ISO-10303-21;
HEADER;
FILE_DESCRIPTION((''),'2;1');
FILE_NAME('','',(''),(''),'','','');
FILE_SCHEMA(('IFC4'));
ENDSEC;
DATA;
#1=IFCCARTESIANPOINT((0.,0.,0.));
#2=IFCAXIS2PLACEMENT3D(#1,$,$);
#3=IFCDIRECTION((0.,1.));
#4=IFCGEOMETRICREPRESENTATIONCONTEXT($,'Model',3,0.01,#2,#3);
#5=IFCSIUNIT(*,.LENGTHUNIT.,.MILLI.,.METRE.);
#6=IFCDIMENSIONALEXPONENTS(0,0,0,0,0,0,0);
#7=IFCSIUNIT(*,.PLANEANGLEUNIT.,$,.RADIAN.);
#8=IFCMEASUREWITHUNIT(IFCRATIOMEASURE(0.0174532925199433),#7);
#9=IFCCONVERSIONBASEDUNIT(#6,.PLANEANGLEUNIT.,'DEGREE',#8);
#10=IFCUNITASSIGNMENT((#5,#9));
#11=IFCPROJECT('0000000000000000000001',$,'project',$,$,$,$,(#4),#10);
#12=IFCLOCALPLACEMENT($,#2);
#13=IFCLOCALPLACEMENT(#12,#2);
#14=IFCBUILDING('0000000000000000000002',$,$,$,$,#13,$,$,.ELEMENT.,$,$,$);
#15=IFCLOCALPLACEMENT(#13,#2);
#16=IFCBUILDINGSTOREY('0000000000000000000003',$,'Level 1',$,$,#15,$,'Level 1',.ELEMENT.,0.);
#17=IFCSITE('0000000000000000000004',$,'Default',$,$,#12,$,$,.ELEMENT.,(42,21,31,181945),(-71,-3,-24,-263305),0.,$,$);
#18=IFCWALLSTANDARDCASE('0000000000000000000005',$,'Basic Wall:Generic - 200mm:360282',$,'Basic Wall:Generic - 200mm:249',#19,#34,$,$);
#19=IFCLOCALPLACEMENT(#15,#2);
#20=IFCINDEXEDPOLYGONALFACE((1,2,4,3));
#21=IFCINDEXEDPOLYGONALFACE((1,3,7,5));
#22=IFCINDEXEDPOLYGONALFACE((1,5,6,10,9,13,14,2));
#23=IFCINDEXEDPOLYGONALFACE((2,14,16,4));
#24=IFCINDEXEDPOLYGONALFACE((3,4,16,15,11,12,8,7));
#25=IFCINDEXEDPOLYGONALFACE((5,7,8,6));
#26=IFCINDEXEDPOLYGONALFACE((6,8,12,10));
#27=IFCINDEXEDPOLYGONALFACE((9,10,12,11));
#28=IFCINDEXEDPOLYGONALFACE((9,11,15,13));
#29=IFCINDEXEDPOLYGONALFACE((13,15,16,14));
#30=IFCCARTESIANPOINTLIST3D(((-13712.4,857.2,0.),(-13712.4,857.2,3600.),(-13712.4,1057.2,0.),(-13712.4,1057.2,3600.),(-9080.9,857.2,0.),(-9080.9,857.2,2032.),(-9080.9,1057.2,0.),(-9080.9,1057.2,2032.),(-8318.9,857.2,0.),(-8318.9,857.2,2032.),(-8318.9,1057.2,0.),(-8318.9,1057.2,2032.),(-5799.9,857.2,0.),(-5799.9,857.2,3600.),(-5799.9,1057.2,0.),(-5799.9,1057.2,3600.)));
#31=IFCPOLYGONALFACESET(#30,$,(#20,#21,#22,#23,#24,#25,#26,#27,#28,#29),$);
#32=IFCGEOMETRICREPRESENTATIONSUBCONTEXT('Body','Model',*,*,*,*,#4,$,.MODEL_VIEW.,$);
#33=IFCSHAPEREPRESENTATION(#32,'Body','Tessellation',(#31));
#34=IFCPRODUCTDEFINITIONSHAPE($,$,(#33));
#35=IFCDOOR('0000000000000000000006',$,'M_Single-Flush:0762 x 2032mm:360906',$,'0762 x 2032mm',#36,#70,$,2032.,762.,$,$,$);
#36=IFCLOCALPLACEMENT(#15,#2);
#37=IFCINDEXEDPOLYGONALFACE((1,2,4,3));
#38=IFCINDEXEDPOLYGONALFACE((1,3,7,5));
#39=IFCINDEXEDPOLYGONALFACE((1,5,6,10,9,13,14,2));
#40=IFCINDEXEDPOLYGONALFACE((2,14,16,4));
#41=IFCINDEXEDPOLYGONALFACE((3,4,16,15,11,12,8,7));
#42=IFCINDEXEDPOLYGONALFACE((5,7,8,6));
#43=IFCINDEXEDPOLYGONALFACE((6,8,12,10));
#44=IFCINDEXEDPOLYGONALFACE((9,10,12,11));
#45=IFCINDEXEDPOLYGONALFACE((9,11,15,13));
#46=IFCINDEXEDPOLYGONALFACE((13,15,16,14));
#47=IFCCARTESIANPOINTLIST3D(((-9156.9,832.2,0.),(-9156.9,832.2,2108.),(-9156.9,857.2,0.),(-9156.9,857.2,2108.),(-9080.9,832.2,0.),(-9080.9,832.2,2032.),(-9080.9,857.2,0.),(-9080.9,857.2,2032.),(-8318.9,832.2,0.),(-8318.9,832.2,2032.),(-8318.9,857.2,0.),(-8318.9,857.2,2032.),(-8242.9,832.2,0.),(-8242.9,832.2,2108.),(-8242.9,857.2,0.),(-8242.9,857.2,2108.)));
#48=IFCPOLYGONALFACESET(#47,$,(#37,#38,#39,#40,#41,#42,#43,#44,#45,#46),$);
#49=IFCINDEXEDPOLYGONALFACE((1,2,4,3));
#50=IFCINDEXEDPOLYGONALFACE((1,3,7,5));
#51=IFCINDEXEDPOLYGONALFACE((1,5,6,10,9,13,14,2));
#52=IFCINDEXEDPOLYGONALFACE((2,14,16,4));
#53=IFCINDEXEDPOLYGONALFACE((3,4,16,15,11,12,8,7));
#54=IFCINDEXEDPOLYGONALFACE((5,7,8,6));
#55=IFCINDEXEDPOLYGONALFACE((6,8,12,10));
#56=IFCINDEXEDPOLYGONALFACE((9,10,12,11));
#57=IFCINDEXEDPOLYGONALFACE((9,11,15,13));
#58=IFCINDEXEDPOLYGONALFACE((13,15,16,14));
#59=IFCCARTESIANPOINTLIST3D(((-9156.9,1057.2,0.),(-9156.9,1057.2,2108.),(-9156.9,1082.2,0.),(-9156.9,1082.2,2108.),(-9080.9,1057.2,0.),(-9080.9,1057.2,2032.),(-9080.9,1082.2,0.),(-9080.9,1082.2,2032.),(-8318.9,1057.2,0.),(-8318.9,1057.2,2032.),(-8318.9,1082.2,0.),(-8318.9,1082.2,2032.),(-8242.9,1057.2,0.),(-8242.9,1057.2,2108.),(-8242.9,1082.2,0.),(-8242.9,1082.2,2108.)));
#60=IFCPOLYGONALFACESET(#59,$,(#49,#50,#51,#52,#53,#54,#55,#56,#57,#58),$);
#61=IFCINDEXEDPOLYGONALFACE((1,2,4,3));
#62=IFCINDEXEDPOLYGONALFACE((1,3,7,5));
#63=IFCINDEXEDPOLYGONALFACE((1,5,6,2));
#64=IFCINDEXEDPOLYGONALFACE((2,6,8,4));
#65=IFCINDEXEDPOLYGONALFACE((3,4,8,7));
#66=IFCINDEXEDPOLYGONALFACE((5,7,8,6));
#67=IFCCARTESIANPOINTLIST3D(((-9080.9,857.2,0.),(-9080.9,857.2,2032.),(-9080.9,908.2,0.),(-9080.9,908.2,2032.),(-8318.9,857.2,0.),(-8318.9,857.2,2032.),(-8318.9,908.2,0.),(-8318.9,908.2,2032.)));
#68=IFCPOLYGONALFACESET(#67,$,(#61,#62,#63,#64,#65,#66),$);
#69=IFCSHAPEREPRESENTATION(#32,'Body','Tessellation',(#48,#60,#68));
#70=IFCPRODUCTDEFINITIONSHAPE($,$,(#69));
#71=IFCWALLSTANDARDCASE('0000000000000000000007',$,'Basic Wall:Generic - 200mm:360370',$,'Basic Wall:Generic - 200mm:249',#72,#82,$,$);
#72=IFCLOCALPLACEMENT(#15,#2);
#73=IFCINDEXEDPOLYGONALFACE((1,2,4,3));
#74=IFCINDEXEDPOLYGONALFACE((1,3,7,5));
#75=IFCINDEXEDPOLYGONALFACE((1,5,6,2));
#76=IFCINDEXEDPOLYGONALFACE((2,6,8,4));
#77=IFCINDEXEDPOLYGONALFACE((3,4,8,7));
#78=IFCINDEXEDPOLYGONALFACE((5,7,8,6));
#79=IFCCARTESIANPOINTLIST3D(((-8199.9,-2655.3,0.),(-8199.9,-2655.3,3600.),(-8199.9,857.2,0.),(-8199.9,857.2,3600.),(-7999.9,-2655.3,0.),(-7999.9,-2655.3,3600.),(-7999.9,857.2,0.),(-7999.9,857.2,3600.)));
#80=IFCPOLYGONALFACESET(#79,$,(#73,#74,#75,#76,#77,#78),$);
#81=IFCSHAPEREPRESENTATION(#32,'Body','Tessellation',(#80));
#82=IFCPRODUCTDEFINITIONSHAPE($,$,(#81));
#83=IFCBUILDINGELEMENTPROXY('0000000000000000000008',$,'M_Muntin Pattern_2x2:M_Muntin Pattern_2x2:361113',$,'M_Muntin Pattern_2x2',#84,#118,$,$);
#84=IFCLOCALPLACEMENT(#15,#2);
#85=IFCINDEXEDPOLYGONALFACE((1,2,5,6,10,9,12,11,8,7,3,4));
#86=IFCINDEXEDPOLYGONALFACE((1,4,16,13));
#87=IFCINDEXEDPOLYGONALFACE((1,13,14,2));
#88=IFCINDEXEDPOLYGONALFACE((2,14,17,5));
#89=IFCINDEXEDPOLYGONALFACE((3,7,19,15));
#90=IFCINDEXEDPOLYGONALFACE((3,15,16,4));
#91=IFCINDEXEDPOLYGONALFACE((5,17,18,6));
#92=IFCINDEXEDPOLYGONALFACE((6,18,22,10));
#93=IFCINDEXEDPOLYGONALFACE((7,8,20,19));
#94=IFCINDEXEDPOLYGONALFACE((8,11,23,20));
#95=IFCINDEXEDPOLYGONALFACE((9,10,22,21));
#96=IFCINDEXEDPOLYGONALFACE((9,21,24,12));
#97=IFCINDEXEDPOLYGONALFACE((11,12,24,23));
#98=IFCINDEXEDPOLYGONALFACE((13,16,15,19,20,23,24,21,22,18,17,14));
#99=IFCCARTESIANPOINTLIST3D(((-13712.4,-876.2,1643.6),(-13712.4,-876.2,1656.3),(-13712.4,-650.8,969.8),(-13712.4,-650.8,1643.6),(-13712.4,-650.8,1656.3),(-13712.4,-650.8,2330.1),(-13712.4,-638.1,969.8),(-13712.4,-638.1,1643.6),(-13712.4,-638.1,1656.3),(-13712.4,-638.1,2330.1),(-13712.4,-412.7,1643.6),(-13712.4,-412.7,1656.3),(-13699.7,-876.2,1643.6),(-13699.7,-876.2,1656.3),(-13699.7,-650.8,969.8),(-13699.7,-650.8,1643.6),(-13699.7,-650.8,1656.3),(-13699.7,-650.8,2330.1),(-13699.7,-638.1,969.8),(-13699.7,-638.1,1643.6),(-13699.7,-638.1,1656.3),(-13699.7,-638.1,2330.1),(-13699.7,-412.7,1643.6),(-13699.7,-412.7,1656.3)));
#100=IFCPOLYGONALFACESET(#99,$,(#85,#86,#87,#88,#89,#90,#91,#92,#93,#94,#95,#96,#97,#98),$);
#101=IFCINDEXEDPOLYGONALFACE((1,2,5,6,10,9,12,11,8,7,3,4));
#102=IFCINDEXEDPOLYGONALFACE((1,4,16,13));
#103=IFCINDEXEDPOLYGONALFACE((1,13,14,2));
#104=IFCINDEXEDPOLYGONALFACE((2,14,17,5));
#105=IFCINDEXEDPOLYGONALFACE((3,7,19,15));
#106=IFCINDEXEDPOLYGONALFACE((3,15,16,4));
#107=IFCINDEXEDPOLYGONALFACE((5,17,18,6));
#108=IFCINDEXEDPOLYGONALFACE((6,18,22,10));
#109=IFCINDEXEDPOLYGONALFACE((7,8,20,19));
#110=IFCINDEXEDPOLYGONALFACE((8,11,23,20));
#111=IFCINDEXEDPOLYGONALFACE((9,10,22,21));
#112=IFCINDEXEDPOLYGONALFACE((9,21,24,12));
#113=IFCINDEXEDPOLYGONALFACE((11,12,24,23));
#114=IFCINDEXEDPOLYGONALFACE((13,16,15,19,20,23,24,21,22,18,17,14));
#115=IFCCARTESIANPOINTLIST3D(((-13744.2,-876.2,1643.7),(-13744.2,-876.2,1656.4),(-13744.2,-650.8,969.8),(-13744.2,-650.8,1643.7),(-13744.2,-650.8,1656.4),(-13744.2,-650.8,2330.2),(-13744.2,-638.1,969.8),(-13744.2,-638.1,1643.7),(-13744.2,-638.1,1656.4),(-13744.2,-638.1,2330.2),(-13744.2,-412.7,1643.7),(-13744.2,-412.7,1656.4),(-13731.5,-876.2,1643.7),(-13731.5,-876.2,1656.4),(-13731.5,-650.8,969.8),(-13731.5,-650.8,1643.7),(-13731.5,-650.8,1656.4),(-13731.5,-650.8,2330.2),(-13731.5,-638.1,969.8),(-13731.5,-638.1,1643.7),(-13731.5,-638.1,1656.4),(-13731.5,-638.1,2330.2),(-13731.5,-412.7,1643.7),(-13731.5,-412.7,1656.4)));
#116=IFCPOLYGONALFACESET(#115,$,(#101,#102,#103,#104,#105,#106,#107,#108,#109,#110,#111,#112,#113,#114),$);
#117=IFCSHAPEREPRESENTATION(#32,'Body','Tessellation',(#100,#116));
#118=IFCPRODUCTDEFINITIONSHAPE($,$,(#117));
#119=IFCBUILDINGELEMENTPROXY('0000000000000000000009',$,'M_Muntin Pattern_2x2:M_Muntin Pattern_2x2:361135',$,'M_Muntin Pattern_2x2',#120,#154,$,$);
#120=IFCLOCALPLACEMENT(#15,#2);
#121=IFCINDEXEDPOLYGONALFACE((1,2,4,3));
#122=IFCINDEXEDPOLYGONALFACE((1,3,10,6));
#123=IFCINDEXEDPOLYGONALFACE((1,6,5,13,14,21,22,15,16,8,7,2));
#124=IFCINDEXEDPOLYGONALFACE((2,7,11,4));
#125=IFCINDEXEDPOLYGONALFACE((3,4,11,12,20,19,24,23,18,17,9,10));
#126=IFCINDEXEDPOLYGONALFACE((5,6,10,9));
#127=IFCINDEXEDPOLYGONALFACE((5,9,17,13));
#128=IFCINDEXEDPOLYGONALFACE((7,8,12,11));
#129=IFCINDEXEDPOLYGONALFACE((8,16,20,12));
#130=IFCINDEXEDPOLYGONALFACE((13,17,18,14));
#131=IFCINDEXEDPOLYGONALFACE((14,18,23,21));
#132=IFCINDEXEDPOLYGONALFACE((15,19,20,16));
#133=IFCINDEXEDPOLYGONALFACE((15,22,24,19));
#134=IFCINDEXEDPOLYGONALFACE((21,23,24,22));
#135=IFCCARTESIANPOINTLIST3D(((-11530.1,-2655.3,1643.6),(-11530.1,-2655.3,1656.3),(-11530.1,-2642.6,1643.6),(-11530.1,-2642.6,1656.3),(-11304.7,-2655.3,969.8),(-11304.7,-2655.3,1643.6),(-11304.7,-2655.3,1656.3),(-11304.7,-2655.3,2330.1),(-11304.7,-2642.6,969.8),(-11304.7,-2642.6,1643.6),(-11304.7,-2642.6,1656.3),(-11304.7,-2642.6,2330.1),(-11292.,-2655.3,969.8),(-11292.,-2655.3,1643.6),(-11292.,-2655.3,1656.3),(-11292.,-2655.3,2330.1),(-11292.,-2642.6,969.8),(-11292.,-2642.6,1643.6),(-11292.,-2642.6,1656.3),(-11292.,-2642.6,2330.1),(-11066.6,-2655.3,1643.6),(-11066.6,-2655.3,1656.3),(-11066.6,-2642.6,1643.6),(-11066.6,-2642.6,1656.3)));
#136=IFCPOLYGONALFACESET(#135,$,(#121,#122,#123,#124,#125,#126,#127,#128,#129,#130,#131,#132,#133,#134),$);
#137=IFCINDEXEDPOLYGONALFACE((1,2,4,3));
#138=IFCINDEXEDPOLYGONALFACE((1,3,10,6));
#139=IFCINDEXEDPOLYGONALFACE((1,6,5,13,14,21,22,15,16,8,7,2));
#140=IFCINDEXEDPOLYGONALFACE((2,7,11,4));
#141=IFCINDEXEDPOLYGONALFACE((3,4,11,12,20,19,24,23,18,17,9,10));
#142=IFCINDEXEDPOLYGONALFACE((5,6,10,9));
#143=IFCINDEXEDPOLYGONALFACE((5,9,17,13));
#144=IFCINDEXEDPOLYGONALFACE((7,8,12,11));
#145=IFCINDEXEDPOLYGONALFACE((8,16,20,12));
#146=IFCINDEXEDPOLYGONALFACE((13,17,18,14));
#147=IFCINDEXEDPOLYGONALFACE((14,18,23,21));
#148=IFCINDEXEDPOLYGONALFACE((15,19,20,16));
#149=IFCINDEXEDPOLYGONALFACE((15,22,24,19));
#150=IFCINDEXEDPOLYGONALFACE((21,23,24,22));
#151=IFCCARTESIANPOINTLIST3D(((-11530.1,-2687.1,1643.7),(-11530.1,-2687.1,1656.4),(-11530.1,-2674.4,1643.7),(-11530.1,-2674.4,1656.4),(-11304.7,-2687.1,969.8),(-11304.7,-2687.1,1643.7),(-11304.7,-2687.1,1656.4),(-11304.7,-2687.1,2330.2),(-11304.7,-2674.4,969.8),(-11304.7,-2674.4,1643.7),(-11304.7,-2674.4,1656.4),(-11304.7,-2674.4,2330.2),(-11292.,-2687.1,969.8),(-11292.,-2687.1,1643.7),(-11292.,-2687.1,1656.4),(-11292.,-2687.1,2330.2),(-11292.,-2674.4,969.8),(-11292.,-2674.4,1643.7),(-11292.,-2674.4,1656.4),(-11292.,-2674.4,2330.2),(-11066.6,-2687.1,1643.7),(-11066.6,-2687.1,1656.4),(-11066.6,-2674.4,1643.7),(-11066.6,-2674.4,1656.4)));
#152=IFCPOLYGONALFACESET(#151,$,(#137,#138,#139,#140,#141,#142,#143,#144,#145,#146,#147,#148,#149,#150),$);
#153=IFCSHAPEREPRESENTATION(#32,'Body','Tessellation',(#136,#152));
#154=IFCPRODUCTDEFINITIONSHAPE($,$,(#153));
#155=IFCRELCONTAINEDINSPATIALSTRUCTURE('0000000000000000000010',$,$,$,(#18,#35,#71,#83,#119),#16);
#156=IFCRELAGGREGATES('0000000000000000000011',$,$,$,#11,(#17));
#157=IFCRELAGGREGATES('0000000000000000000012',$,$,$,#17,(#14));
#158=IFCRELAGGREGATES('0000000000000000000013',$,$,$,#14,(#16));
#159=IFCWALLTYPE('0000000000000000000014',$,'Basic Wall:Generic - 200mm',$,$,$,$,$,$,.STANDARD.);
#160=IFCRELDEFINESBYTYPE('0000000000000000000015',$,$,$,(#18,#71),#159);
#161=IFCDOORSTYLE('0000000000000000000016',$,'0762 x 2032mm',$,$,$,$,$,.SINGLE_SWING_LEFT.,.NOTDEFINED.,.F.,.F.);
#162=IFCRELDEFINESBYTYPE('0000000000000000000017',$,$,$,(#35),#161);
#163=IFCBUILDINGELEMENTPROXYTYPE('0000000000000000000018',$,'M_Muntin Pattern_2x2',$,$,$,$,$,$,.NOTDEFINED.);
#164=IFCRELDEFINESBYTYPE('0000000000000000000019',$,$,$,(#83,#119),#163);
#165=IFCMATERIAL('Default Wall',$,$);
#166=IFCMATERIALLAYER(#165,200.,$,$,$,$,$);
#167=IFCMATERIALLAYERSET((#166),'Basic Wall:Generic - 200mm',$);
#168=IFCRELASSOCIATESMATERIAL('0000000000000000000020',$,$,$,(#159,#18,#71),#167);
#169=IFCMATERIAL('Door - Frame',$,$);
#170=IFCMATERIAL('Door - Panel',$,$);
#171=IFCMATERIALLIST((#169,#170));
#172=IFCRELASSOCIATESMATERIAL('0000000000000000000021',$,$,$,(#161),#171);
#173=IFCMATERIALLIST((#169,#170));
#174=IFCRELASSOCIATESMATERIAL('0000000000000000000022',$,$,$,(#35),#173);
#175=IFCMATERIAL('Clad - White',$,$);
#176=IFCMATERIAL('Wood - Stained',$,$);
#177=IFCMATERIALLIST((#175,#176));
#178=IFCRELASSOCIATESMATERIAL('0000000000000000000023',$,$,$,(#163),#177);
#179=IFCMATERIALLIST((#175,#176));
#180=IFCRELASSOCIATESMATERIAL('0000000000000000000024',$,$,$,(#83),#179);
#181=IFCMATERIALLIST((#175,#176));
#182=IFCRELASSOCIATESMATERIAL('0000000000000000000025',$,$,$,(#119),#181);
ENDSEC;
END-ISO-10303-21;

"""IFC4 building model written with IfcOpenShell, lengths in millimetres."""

from ifc_helpers import new_model, entity, si_unit, converted_unit, direction, frame, frame_2d, origin, place, context, subcontext, project, spatial, polyline, rectangle, outline, extrude, clip, bounded_halfspace, source, transform, mapped, material, material_list, layer, layer_set, layer_usage, type_object, type_shapes, element, fill, save


model = new_model("IFC4")

# Units and contexts
model_context = context("Model", 3, precision=0.01, world=origin(), true_north=direction((0.0, 1.0)))
body_context = subcontext(model_context, "Body", "Model", "MODEL_VIEW")
ifc_project = project(units=[si_unit("LENGTHUNIT", "METRE", prefix="MILLI"), converted_unit("PLANEANGLEUNIT", "DEGREE", entity("IfcRatioMeasure", 0.0174532925199433), si_unit("PLANEANGLEUNIT", "RADIAN"), dimensions=[0, 0, 0, 0, 0, 0, 0])], contexts=[model_context])

# Site, building, storey
site_placement = place(None, origin())
site = spatial("IfcSite", under=ifc_project, at=site_placement, Name="Default", CompositionType="ELEMENT", RefLatitude=(42, 21, 31, 181945), RefLongitude=(-71, -3, -24, -263305), RefElevation=0.0)
building_placement = place(site_placement, origin())
building = spatial("IfcBuilding", under=site, at=building_placement, CompositionType="ELEMENT")
storey_placement = place(building_placement, origin())
storey = spatial("IfcBuildingStorey", under=building, at=storey_placement, Name="Level 1", LongName="Level 1", CompositionType="ELEMENT", Elevation=0.0)

# Shared definitions
ifc_material_1 = material(Name="Default Wall")

# Wall, opening, door
ifc_material_2 = material(Name="Door - Frame")
ifc_material_3 = material(Name="Door - Panel")
ifc_layer_1 = layer(ifc_material_1, 200.0)
ifc_layer_set_1 = layer_set([ifc_layer_1], Name="Basic Wall:Generic - 200mm")
wall_type_1 = type_object("IfcWallType", Name="Basic Wall:Generic - 200mm", PredefinedType="STANDARD", material=ifc_layer_set_1)
ifc_material_list_1 = material_list([ifc_material_2, ifc_material_3])
door_style_1 = type_object("IfcDoorStyle", Name="0762 x 2032mm", ConstructionType="NOTDEFINED", OperationType="SINGLE_SWING_LEFT", ParameterTakesPrecedence=False, Sizeable=False, material=ifc_material_list_1)
shared_shape_1 = source(origin(), body_context, "Body", "SweptSolid", [
    extrude(outline(polyline([(-457.0, -1073.0), (457.0, -1073.0), (457.0, 1035.0), (381.0, 1035.0), (381.0, -997.0), (-381.0, -997.0), (-381.0, 1035.0), (-457.0, 1035.0), (-457.0, -1073.0)])), frame((381.0, 225.0, 1035.0), z_axis=(0.0, -1.0, 0.0), x_axis=(-1.0, 0.0, 0.0)), (0.0, 0.0, 1.0), 25.0),
    extrude(outline(polyline([(-1073.0, -457.0), (1035.0, -457.0), (1035.0, -381.0), (-997.0, -381.0), (-997.0, 381.0), (1035.0, 381.0), (1035.0, 457.0), (-1073.0, 457.0), (-1073.0, -457.0)])), frame((381.0, 0.0, 1035.0), z_axis=(0.0, -1.0, 0.0), x_axis=(0.0, 0.0, -1.0)), (0.0, 0.0, 1.0), 25.0),
    extrude(rectangle(XDim=762.0, YDim=51.0, at=frame_2d((0.0, 0.0), x_axis=(1.0, 0.0))), frame((381.0, 174.5, 0.0)), (0.0, 0.0, 1.0), 2032.0),
])
type_shapes(door_style_1, [shared_shape_1])
ifc_layer_usage_1 = layer_usage(ifc_layer_set_1, "AXIS2", "NEGATIVE", 100.0)
wall_1_placement = place(storey_placement, frame((-5799.9, 957.2, 0.0), z_axis=(0.0, 0.0, 1.0), x_axis=(-1.0, 0.0, 0.0)))
wall_1 = element("IfcWallStandardCase", 1, at=wall_1_placement, inside=storey, type_object=wall_type_1, material=ifc_layer_usage_1, Name="Basic Wall:Generic - 200mm:360282", ObjectType="Basic Wall:Generic - 200mm:249", context=body_context, shape_type="Clipping", body=[
    clip(extrude(rectangle(XDim=7912.5, YDim=200.0, at=frame_2d((3956.2, 0.0), x_axis=(-1.0, 0.0))), origin(), (0.0, 0.0, 1.0), 3600.0), bounded_halfspace(frame((0.0, -100.0, 3600.0), z_axis=(0.0, 0.0, -1.0), x_axis=(-1.0, 0.0, 0.0)), True, frame((0.0, -100.0, 3600.0)), polyline([(0.0, 0.0), (200.0, 0.0), (4500.0, 0.0), (4700.0, 0.0), (7912.5, 0.0), (7912.5, 200.0), (2400.0, 200.0), (2200.0, 200.0), (0.0, 200.0), (0.0, 0.0)]))),
])
opening_1_placement = place(wall_1_placement, frame((2519.0, -100.0, 0.0)))
opening_1 = element("IfcOpeningElement", 2, at=opening_1_placement, cuts=wall_1, ObjectType="Opening", context=body_context, shape_type="SweptSolid", body=[
    extrude(rectangle(XDim=762.0, YDim=2032.0, at=frame_2d((1016.0, 381.0), x_axis=(0.0, -1.0))), frame((0.0, 0.0, 0.0), z_axis=(0.0, 1.0, 0.0), x_axis=(0.0, 0.0, 1.0)), (0.0, 0.0, 1.0), 200.0),
])
ifc_material_list_2 = material_list([ifc_material_2, ifc_material_3])
door_1_placement = place(opening_1_placement, origin())
door_1 = element("IfcDoor", 3, at=door_1_placement, inside=storey, type_object=door_style_1, material=ifc_material_list_2, Name="M_Single-Flush:0762 x 2032mm:360906", ObjectType="0762 x 2032mm", OverallHeight=2032.0, OverallWidth=762.0, context=body_context, shape_type="MappedRepresentation", body=[
    mapped(shared_shape_1, transform((0.0, 0.0, 0.0), scale=1.0)),
])
fill(opening_1, door_1)

# Wall
ifc_layer_usage_2 = layer_usage(ifc_layer_set_1, "AXIS2", "NEGATIVE", 100.0)
wall_2_placement = place(storey_placement, frame((-8099.9, 857.2, 0.0), z_axis=(0.0, 0.0, 1.0), x_axis=(0.0, -1.0, 0.0)))
element("IfcWallStandardCase", 4, at=wall_2_placement, inside=storey, type_object=wall_type_1, material=ifc_layer_usage_2, Name="Basic Wall:Generic - 200mm:360370", ObjectType="Basic Wall:Generic - 200mm:249", context=body_context, shape_type="Clipping", body=[
    clip(extrude(rectangle(XDim=3512.5, YDim=200.0, at=frame_2d((1756.2, 0.0), x_axis=(-1.0, 0.0))), origin(), (0.0, 0.0, 1.0), 3600.0), bounded_halfspace(frame((0.0, -100.0, 3600.0), z_axis=(0.0, 0.0, -1.0), x_axis=(0.0, 1.0, 0.0)), True, frame((0.0, -100.0, 3600.0)), polyline([(0.0, 0.0), (3512.5, 0.0), (3512.5, 200.0), (0.0, 200.0), (0.0, 0.0)]))),
])

# Building element proxies
ifc_material_4 = material(Name="Clad - White")
ifc_material_5 = material(Name="Wood - Stained")
ifc_material_list_3 = material_list([ifc_material_4, ifc_material_5])
ifc_material_list_4 = material_list([ifc_material_4, ifc_material_5])
building_element_proxy_type_1 = type_object("IfcBuildingElementProxyType", Name="M_Muntin Pattern_2x2", PredefinedType="NOTDEFINED", material=ifc_material_list_4)
shared_shape_2 = source(origin(), body_context, "Body", "SweptSolid", [
    extrude(outline(polyline([(6.4, -6.4), (680.1, -6.4), (680.1, 6.3), (6.4, 6.3), (6.4, 231.7), (-6.3, 231.7), (-6.3, 6.3), (-680.2, 6.3), (-680.2, -6.4), (-6.3, -6.4), (-6.3, -231.7), (6.4, -231.7), (6.4, -6.4)])), frame((0.0, 9.5, 680.1), z_axis=(0.0, 1.0, 0.0), x_axis=(0.0, 0.0, 1.0)), (0.0, 0.0, 1.0), 12.7),
    extrude(outline(polyline([(6.4, -6.4), (680.2, -6.4), (680.2, 6.3), (6.4, 6.3), (6.4, 231.7), (-6.3, 231.7), (-6.3, 6.3), (-680.2, 6.3), (-680.2, -6.4), (-6.3, -6.4), (-6.3, -231.7), (6.4, -231.7), (6.4, -6.4)])), frame((0.0, -22.2, 680.2), z_axis=(0.0, 1.0, 0.0), x_axis=(0.0, 0.0, 1.0)), (0.0, 0.0, 1.0), 12.7),
])
type_shapes(building_element_proxy_type_1, [shared_shape_2])
proxy_1_placement = place(storey_placement, frame((-13722.0, -644.4, 969.8), z_axis=(0.0, 0.0, 1.0), x_axis=(0.0, -1.0, 0.0)))
element("IfcBuildingElementProxy", 5, at=proxy_1_placement, inside=storey, type_object=building_element_proxy_type_1, material=ifc_material_list_3, Name="M_Muntin Pattern_2x2:M_Muntin Pattern_2x2:361113", ObjectType="M_Muntin Pattern_2x2", context=body_context, shape_type="MappedRepresentation", body=[
    mapped(shared_shape_2, transform((0.0, 0.0, 0.0), scale=1.0)),
])
ifc_material_list_5 = material_list([ifc_material_4, ifc_material_5])
proxy_2_placement = place(storey_placement, frame((-11298.4, -2664.9, 969.8)))
element("IfcBuildingElementProxy", 6, at=proxy_2_placement, inside=storey, type_object=building_element_proxy_type_1, material=ifc_material_list_5, Name="M_Muntin Pattern_2x2:M_Muntin Pattern_2x2:361135", ObjectType="M_Muntin Pattern_2x2", context=body_context, shape_type="MappedRepresentation", body=[
    mapped(shared_shape_2, transform((0.0, 0.0, 0.0), scale=1.0)),
])

save(model, "model.ifc")
